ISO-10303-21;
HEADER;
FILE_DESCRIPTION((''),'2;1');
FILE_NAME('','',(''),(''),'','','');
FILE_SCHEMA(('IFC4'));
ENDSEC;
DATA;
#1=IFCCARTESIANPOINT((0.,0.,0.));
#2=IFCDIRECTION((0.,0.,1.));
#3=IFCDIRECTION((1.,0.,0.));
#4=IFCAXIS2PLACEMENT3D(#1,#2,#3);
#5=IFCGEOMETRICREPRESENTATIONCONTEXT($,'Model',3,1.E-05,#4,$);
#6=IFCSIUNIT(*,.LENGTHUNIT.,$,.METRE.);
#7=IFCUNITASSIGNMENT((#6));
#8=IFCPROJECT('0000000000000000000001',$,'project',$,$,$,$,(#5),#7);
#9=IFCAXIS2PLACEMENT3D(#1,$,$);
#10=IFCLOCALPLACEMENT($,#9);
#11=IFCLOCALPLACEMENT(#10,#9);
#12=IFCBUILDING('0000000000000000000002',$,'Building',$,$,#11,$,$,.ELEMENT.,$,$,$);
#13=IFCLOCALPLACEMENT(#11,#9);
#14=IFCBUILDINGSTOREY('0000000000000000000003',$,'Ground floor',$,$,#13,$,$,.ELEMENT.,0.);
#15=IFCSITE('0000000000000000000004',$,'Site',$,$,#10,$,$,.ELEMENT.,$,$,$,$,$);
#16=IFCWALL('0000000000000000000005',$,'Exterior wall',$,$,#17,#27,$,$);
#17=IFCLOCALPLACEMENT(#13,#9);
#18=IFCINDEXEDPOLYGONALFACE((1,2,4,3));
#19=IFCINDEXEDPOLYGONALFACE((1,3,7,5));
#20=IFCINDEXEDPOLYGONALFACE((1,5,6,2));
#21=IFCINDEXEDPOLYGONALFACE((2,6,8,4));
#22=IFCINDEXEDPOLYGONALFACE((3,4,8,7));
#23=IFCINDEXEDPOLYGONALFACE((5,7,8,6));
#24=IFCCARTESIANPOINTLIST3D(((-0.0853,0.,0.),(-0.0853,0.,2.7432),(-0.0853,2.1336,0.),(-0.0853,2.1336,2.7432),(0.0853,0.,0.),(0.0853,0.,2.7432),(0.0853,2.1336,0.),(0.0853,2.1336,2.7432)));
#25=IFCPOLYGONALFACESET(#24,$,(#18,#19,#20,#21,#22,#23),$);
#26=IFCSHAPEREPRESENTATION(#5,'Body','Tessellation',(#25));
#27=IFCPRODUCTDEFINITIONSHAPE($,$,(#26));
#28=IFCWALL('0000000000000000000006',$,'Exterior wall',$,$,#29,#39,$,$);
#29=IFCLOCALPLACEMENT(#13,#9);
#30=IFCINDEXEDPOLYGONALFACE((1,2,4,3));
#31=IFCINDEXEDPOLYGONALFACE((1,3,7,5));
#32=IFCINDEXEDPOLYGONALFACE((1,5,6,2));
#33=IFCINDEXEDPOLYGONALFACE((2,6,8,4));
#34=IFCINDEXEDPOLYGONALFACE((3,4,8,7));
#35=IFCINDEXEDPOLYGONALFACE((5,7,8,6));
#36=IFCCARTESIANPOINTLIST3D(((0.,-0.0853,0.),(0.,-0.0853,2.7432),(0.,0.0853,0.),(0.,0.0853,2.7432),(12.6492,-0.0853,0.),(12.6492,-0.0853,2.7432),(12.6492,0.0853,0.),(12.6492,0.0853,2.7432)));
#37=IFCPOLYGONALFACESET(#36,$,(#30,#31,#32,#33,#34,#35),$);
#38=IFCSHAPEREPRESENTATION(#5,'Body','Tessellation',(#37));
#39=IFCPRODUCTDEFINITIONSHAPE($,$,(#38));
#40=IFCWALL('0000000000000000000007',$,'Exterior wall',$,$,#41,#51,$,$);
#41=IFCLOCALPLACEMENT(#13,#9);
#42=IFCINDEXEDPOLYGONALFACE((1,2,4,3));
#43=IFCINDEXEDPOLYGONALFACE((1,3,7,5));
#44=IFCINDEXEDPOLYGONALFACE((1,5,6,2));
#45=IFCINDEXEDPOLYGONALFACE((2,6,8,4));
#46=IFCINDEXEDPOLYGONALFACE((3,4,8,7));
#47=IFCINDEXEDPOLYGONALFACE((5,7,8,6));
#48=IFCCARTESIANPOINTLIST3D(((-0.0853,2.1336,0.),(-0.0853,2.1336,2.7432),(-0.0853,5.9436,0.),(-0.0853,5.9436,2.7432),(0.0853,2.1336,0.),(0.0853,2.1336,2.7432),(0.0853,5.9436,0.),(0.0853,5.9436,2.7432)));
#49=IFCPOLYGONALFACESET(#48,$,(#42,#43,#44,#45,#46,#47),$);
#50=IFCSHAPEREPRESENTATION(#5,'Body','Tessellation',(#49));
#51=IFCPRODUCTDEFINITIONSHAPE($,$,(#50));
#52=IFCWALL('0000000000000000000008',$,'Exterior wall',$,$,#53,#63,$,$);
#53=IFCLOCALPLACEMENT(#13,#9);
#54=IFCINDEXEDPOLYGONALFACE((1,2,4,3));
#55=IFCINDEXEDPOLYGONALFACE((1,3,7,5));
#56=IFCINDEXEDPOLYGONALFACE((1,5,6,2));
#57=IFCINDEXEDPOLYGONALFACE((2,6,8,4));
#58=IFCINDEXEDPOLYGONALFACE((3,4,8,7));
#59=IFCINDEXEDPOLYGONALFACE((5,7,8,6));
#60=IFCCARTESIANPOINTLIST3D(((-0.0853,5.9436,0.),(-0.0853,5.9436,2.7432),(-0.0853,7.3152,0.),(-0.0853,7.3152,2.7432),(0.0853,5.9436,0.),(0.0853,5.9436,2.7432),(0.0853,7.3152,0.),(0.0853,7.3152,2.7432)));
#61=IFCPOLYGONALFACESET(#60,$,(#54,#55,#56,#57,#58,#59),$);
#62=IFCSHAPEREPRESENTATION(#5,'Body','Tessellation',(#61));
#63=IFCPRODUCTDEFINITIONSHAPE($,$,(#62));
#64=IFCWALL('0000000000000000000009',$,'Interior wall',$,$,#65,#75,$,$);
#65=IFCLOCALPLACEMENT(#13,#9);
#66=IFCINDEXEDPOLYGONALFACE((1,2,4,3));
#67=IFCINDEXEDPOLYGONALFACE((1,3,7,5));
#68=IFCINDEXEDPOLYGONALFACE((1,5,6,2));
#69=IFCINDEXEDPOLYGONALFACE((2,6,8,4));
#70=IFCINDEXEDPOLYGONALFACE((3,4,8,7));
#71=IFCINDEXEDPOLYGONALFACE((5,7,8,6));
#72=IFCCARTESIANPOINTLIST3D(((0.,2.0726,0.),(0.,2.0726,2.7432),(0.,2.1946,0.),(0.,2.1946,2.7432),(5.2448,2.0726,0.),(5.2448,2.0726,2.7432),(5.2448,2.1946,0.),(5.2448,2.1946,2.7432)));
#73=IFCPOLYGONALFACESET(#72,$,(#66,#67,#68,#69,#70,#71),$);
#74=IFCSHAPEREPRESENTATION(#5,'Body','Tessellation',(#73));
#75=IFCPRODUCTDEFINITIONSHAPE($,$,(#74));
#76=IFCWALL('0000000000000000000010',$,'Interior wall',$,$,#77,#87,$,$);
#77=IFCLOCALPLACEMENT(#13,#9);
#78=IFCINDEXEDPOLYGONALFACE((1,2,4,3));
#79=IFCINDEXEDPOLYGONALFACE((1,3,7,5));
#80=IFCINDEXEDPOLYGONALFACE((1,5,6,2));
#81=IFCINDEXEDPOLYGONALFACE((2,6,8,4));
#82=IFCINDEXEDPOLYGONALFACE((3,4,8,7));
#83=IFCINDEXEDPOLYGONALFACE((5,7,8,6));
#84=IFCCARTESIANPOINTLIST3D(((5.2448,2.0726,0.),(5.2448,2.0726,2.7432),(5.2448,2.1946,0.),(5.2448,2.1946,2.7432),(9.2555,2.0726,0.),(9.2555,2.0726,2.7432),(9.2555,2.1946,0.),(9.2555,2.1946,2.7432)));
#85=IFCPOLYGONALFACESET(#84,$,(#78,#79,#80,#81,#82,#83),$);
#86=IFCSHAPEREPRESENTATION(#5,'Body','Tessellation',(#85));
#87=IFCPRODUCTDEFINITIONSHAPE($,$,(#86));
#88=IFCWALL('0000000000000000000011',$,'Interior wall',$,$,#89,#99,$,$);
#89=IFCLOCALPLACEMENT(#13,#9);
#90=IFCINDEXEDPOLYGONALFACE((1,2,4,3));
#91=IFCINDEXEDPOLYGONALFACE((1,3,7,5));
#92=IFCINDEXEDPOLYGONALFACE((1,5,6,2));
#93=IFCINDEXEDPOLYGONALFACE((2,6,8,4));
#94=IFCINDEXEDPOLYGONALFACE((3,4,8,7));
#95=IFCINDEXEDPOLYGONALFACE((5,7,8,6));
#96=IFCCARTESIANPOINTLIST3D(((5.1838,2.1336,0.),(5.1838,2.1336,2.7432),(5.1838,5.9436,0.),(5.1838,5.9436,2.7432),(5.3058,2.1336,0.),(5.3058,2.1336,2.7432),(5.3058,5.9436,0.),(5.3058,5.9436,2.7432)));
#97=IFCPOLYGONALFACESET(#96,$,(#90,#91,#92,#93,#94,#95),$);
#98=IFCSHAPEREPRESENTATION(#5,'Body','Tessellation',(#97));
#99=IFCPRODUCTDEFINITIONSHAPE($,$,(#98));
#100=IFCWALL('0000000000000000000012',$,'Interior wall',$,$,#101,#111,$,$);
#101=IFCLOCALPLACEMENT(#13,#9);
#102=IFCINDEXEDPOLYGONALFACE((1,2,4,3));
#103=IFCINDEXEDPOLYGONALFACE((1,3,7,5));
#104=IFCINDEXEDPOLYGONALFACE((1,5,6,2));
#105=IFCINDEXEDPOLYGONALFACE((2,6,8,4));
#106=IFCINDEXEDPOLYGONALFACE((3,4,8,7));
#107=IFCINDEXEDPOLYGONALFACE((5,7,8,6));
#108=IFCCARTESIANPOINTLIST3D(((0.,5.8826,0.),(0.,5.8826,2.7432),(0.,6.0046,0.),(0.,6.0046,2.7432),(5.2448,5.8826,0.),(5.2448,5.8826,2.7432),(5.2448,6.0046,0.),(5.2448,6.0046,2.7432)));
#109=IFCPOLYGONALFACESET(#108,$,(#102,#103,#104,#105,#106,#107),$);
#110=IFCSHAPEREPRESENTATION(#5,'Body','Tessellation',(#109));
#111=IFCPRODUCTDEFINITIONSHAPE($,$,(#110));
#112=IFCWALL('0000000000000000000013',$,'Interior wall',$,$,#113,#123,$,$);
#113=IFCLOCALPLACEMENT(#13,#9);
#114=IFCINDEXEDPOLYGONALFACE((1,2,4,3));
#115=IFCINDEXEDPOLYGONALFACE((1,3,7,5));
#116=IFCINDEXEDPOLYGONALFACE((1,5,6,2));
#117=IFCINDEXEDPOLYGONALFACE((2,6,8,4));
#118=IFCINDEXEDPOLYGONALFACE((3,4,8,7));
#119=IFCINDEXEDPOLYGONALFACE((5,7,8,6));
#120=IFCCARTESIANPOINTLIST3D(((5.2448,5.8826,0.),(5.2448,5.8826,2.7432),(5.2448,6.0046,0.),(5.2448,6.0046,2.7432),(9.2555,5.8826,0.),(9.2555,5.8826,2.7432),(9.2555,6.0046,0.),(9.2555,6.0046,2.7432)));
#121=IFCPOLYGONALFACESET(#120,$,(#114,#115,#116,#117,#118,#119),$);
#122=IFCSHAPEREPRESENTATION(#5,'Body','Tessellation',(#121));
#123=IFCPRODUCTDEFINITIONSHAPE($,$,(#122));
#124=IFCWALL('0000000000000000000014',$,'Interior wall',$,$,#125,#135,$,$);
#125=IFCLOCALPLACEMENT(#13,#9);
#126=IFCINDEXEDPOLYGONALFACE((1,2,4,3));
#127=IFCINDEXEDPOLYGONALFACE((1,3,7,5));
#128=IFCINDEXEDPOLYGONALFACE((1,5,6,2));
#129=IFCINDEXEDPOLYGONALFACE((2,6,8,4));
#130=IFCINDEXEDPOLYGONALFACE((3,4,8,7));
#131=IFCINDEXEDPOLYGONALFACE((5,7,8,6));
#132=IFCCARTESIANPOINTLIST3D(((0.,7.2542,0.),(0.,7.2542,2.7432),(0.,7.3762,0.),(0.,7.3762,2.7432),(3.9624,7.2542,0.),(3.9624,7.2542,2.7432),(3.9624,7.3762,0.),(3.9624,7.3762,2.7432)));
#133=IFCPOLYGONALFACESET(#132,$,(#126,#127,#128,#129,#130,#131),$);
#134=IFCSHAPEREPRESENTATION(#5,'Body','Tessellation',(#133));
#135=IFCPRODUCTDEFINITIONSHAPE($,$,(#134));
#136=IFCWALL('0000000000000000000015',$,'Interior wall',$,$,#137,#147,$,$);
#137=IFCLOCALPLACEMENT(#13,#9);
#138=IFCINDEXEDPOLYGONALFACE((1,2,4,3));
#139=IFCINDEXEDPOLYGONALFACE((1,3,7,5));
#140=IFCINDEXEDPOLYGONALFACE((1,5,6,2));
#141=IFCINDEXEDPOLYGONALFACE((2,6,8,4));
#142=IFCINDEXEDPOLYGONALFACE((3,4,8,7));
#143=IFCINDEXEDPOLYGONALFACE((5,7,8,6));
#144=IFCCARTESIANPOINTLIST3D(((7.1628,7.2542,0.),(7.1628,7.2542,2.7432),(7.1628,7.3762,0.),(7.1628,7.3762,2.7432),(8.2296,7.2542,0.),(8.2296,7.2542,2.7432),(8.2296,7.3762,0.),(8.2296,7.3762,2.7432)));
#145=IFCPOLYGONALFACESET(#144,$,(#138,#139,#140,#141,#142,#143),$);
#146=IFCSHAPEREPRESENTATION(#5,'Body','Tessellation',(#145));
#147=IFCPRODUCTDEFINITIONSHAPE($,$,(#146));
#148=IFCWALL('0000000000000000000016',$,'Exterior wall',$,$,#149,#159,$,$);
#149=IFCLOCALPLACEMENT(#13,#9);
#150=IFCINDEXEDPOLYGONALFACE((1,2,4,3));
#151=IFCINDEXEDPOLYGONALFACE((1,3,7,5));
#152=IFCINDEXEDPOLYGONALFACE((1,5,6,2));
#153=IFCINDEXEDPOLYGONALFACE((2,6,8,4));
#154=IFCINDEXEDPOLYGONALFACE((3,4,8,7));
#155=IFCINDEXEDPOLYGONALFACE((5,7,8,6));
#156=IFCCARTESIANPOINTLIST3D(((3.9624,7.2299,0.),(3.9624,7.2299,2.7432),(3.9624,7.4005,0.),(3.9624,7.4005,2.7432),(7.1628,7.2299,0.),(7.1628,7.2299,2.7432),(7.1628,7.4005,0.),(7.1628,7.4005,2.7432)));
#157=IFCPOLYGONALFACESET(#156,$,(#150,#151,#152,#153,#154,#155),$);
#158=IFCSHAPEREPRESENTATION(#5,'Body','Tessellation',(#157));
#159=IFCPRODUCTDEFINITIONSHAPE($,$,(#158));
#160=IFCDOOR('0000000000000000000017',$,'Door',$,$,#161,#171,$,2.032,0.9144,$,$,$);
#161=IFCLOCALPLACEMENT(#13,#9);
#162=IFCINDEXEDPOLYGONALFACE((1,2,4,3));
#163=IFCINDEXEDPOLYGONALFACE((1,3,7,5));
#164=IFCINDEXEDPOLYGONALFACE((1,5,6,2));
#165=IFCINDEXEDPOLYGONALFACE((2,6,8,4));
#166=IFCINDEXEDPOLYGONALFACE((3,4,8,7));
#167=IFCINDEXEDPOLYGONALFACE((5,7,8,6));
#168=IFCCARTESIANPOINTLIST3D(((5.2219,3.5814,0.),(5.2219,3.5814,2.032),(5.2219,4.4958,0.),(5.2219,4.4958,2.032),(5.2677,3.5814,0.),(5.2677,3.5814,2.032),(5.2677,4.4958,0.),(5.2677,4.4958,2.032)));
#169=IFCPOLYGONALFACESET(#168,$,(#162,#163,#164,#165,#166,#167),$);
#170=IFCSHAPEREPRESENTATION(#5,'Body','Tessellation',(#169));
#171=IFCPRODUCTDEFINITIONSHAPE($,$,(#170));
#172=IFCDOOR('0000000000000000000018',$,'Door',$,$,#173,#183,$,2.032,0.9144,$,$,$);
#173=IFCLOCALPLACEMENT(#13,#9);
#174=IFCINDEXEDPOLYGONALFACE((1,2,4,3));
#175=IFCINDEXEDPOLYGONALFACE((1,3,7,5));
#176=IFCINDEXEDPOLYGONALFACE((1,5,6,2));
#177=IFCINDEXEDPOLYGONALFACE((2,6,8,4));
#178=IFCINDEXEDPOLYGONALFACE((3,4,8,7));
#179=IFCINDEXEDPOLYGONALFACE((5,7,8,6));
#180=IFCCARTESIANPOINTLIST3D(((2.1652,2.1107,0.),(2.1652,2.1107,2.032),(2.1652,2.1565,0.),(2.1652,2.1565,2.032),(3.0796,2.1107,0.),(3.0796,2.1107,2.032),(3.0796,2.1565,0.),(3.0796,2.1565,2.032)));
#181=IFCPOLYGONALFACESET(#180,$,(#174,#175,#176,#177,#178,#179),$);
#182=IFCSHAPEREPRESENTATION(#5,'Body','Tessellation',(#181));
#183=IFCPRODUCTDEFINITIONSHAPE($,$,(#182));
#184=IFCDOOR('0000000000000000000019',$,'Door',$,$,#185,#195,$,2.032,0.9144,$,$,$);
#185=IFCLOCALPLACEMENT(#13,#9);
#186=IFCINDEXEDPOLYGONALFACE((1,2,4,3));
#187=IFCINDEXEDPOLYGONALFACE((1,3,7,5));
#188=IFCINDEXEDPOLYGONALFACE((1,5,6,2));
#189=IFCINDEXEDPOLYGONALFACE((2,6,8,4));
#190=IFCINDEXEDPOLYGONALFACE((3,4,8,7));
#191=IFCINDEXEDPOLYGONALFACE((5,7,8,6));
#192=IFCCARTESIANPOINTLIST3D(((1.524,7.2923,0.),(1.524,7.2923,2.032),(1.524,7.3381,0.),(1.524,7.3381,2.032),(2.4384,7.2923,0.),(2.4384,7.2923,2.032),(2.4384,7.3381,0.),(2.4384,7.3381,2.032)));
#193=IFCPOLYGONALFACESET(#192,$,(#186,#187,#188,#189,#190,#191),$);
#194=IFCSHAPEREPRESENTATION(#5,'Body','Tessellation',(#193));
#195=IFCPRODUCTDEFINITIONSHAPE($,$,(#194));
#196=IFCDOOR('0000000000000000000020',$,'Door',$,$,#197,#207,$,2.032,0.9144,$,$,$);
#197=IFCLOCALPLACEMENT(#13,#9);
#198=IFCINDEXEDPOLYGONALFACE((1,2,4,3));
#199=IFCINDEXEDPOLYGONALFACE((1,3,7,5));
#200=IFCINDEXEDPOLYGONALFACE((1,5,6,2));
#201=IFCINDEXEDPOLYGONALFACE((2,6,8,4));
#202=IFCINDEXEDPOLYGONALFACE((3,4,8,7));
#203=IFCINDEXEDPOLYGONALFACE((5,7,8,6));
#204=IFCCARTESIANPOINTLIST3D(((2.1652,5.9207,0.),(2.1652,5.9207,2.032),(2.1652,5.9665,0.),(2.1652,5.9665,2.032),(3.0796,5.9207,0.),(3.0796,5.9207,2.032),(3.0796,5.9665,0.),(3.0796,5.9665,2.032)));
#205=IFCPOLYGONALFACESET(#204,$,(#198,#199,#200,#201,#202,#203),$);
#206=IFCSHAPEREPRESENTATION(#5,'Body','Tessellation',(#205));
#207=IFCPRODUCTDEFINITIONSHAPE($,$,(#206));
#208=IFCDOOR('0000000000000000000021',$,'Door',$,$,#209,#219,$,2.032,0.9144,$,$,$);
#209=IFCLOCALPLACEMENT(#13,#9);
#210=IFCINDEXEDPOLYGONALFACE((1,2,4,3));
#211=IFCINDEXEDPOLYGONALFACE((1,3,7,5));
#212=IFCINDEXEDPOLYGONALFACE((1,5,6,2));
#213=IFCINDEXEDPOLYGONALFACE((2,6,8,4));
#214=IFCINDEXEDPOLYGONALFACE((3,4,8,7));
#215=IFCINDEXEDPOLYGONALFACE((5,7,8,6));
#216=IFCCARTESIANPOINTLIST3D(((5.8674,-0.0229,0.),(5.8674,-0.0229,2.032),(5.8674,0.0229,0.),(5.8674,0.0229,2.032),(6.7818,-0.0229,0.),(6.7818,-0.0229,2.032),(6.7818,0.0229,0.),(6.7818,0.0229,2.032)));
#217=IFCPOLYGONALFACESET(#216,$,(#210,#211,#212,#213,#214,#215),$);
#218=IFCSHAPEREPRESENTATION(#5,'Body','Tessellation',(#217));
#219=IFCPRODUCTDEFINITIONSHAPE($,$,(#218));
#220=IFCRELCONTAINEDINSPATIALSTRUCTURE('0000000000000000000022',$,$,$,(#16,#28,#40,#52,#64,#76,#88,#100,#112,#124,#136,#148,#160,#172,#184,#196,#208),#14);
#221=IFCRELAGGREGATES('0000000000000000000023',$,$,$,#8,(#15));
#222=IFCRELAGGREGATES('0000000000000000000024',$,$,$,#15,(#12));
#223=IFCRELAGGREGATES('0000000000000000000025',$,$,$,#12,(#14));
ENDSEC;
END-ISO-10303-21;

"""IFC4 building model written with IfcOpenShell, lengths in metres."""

from ifc_helpers import new_model, si_unit, frame, origin, origin_with_axes, origin_2d, place, context, project, spatial, rectangle, extrude, element, save


model = new_model("IFC4")

# Units and contexts
model_context = context("Model", 3, precision=1e-05, world=origin_with_axes())
ifc_project = project(units=[si_unit("LENGTHUNIT", "METRE")], contexts=[model_context])

# Site, building, storey
site_placement = place(None, origin())
site = spatial("IfcSite", under=ifc_project, at=site_placement, Name="Site", CompositionType="ELEMENT")
building_placement = place(site_placement, origin())
building = spatial("IfcBuilding", under=site, at=building_placement, Name="Building", CompositionType="ELEMENT")
storey_placement = place(building_placement, origin())
storey = spatial("IfcBuildingStorey", under=building, at=storey_placement, Name="Ground floor", CompositionType="ELEMENT", Elevation=0.0)

# Walls
wall_1_placement = place(storey_placement, frame((0.0, 1.0668, 0.0), x_axis=(0.0, 1.0, 0.0)))
element("IfcWall", 1, at=wall_1_placement, inside=storey, Name="Exterior wall", context=model_context, shape_type="SweptSolid", body=[
    extrude(rectangle(XDim=2.1336, YDim=0.1707, at=origin_2d()), origin(), (0.0, 0.0, 1.0), 2.7432),
])
wall_2_placement = place(storey_placement, frame((6.3246, 0.0, 0.0), x_axis=(1.0, 0.0, 0.0)))
element("IfcWall", 2, at=wall_2_placement, inside=storey, Name="Exterior wall", context=model_context, shape_type="SweptSolid", body=[
    extrude(rectangle(XDim=12.6492, YDim=0.1707, at=origin_2d()), origin(), (0.0, 0.0, 1.0), 2.7432),
])
wall_3_placement = place(storey_placement, frame((0.0, 4.0386, 0.0), x_axis=(0.0, 1.0, 0.0)))
element("IfcWall", 3, at=wall_3_placement, inside=storey, Name="Exterior wall", context=model_context, shape_type="SweptSolid", body=[
    extrude(rectangle(XDim=3.81, YDim=0.1707, at=origin_2d()), origin(), (0.0, 0.0, 1.0), 2.7432),
])
wall_4_placement = place(storey_placement, frame((0.0, 6.6294, 0.0), x_axis=(0.0, 1.0, 0.0)))
element("IfcWall", 4, at=wall_4_placement, inside=storey, Name="Exterior wall", context=model_context, shape_type="SweptSolid", body=[
    extrude(rectangle(XDim=1.3716, YDim=0.1707, at=origin_2d()), origin(), (0.0, 0.0, 1.0), 2.7432),
])
wall_5_placement = place(storey_placement, frame((2.6224, 2.1336, 0.0), x_axis=(1.0, 0.0, 0.0)))
element("IfcWall", 5, at=wall_5_placement, inside=storey, Name="Interior wall", context=model_context, shape_type="SweptSolid", body=[
    extrude(rectangle(XDim=5.2448, YDim=0.1219, at=origin_2d()), origin(), (0.0, 0.0, 1.0), 2.7432),
])
wall_6_placement = place(storey_placement, frame((7.2502, 2.1336, 0.0), x_axis=(1.0, 0.0, 0.0)))
element("IfcWall", 6, at=wall_6_placement, inside=storey, Name="Interior wall", context=model_context, shape_type="SweptSolid", body=[
    extrude(rectangle(XDim=4.0107, YDim=0.1219, at=origin_2d()), origin(), (0.0, 0.0, 1.0), 2.7432),
])
wall_7_placement = place(storey_placement, frame((5.2448, 4.0386, 0.0), x_axis=(0.0, 1.0, 0.0)))
element("IfcWall", 7, at=wall_7_placement, inside=storey, Name="Interior wall", context=model_context, shape_type="SweptSolid", body=[
    extrude(rectangle(XDim=3.81, YDim=0.1219, at=origin_2d()), origin(), (0.0, 0.0, 1.0), 2.7432),
])
wall_8_placement = place(storey_placement, frame((2.6224, 5.9436, 0.0), x_axis=(1.0, 0.0, 0.0)))
element("IfcWall", 8, at=wall_8_placement, inside=storey, Name="Interior wall", context=model_context, shape_type="SweptSolid", body=[
    extrude(rectangle(XDim=5.2448, YDim=0.1219, at=origin_2d()), origin(), (0.0, 0.0, 1.0), 2.7432),
])
wall_9_placement = place(storey_placement, frame((7.2502, 5.9436, 0.0), x_axis=(1.0, 0.0, 0.0)))
element("IfcWall", 9, at=wall_9_placement, inside=storey, Name="Interior wall", context=model_context, shape_type="SweptSolid", body=[
    extrude(rectangle(XDim=4.0107, YDim=0.1219, at=origin_2d()), origin(), (0.0, 0.0, 1.0), 2.7432),
])
wall_10_placement = place(storey_placement, frame((1.9812, 7.3152, 0.0), x_axis=(1.0, 0.0, 0.0)))
element("IfcWall", 10, at=wall_10_placement, inside=storey, Name="Interior wall", context=model_context, shape_type="SweptSolid", body=[
    extrude(rectangle(XDim=3.9624, YDim=0.1219, at=origin_2d()), origin(), (0.0, 0.0, 1.0), 2.7432),
])
wall_11_placement = place(storey_placement, frame((7.6962, 7.3152, 0.0), x_axis=(1.0, 0.0, 0.0)))
element("IfcWall", 11, at=wall_11_placement, inside=storey, Name="Interior wall", context=model_context, shape_type="SweptSolid", body=[
    extrude(rectangle(XDim=1.0668, YDim=0.1219, at=origin_2d()), origin(), (0.0, 0.0, 1.0), 2.7432),
])
wall_12_placement = place(storey_placement, frame((5.5626, 7.3152, 0.0), x_axis=(1.0, 0.0, 0.0)))
element("IfcWall", 12, at=wall_12_placement, inside=storey, Name="Exterior wall", context=model_context, shape_type="SweptSolid", body=[
    extrude(rectangle(XDim=3.2004, YDim=0.1707, at=origin_2d()), origin(), (0.0, 0.0, 1.0), 2.7432),
])

# Doors
for number, where, x_axis, name in (
    (13, (5.2448, 4.0386, 0.0), (0.0, 1.0, 0.0), "Door"),
    (14, (2.6224, 2.1336, 0.0), (1.0, 0.0, 0.0), "Door"),
    (15, (1.9812, 7.3152, 0.0), (1.0, 0.0, 0.0), "Door"),
    (16, (2.6224, 5.9436, 0.0), (1.0, 0.0, 0.0), "Door"),
    (17, (6.3246, 0.0, 0.0), (1.0, 0.0, 0.0), "Door"),
):
    element("IfcDoor", number, at=place(storey_placement, frame(where, x_axis=x_axis)), inside=storey, Name=name, OverallHeight=2.032, OverallWidth=0.9144, context=model_context, shape_type="SweptSolid", body=[
        extrude(rectangle(XDim=0.9144, YDim=0.0457, at=origin_2d()), origin(), (0.0, 0.0, 1.0), 2.032),
    ])

save(model, "model.ifc")
